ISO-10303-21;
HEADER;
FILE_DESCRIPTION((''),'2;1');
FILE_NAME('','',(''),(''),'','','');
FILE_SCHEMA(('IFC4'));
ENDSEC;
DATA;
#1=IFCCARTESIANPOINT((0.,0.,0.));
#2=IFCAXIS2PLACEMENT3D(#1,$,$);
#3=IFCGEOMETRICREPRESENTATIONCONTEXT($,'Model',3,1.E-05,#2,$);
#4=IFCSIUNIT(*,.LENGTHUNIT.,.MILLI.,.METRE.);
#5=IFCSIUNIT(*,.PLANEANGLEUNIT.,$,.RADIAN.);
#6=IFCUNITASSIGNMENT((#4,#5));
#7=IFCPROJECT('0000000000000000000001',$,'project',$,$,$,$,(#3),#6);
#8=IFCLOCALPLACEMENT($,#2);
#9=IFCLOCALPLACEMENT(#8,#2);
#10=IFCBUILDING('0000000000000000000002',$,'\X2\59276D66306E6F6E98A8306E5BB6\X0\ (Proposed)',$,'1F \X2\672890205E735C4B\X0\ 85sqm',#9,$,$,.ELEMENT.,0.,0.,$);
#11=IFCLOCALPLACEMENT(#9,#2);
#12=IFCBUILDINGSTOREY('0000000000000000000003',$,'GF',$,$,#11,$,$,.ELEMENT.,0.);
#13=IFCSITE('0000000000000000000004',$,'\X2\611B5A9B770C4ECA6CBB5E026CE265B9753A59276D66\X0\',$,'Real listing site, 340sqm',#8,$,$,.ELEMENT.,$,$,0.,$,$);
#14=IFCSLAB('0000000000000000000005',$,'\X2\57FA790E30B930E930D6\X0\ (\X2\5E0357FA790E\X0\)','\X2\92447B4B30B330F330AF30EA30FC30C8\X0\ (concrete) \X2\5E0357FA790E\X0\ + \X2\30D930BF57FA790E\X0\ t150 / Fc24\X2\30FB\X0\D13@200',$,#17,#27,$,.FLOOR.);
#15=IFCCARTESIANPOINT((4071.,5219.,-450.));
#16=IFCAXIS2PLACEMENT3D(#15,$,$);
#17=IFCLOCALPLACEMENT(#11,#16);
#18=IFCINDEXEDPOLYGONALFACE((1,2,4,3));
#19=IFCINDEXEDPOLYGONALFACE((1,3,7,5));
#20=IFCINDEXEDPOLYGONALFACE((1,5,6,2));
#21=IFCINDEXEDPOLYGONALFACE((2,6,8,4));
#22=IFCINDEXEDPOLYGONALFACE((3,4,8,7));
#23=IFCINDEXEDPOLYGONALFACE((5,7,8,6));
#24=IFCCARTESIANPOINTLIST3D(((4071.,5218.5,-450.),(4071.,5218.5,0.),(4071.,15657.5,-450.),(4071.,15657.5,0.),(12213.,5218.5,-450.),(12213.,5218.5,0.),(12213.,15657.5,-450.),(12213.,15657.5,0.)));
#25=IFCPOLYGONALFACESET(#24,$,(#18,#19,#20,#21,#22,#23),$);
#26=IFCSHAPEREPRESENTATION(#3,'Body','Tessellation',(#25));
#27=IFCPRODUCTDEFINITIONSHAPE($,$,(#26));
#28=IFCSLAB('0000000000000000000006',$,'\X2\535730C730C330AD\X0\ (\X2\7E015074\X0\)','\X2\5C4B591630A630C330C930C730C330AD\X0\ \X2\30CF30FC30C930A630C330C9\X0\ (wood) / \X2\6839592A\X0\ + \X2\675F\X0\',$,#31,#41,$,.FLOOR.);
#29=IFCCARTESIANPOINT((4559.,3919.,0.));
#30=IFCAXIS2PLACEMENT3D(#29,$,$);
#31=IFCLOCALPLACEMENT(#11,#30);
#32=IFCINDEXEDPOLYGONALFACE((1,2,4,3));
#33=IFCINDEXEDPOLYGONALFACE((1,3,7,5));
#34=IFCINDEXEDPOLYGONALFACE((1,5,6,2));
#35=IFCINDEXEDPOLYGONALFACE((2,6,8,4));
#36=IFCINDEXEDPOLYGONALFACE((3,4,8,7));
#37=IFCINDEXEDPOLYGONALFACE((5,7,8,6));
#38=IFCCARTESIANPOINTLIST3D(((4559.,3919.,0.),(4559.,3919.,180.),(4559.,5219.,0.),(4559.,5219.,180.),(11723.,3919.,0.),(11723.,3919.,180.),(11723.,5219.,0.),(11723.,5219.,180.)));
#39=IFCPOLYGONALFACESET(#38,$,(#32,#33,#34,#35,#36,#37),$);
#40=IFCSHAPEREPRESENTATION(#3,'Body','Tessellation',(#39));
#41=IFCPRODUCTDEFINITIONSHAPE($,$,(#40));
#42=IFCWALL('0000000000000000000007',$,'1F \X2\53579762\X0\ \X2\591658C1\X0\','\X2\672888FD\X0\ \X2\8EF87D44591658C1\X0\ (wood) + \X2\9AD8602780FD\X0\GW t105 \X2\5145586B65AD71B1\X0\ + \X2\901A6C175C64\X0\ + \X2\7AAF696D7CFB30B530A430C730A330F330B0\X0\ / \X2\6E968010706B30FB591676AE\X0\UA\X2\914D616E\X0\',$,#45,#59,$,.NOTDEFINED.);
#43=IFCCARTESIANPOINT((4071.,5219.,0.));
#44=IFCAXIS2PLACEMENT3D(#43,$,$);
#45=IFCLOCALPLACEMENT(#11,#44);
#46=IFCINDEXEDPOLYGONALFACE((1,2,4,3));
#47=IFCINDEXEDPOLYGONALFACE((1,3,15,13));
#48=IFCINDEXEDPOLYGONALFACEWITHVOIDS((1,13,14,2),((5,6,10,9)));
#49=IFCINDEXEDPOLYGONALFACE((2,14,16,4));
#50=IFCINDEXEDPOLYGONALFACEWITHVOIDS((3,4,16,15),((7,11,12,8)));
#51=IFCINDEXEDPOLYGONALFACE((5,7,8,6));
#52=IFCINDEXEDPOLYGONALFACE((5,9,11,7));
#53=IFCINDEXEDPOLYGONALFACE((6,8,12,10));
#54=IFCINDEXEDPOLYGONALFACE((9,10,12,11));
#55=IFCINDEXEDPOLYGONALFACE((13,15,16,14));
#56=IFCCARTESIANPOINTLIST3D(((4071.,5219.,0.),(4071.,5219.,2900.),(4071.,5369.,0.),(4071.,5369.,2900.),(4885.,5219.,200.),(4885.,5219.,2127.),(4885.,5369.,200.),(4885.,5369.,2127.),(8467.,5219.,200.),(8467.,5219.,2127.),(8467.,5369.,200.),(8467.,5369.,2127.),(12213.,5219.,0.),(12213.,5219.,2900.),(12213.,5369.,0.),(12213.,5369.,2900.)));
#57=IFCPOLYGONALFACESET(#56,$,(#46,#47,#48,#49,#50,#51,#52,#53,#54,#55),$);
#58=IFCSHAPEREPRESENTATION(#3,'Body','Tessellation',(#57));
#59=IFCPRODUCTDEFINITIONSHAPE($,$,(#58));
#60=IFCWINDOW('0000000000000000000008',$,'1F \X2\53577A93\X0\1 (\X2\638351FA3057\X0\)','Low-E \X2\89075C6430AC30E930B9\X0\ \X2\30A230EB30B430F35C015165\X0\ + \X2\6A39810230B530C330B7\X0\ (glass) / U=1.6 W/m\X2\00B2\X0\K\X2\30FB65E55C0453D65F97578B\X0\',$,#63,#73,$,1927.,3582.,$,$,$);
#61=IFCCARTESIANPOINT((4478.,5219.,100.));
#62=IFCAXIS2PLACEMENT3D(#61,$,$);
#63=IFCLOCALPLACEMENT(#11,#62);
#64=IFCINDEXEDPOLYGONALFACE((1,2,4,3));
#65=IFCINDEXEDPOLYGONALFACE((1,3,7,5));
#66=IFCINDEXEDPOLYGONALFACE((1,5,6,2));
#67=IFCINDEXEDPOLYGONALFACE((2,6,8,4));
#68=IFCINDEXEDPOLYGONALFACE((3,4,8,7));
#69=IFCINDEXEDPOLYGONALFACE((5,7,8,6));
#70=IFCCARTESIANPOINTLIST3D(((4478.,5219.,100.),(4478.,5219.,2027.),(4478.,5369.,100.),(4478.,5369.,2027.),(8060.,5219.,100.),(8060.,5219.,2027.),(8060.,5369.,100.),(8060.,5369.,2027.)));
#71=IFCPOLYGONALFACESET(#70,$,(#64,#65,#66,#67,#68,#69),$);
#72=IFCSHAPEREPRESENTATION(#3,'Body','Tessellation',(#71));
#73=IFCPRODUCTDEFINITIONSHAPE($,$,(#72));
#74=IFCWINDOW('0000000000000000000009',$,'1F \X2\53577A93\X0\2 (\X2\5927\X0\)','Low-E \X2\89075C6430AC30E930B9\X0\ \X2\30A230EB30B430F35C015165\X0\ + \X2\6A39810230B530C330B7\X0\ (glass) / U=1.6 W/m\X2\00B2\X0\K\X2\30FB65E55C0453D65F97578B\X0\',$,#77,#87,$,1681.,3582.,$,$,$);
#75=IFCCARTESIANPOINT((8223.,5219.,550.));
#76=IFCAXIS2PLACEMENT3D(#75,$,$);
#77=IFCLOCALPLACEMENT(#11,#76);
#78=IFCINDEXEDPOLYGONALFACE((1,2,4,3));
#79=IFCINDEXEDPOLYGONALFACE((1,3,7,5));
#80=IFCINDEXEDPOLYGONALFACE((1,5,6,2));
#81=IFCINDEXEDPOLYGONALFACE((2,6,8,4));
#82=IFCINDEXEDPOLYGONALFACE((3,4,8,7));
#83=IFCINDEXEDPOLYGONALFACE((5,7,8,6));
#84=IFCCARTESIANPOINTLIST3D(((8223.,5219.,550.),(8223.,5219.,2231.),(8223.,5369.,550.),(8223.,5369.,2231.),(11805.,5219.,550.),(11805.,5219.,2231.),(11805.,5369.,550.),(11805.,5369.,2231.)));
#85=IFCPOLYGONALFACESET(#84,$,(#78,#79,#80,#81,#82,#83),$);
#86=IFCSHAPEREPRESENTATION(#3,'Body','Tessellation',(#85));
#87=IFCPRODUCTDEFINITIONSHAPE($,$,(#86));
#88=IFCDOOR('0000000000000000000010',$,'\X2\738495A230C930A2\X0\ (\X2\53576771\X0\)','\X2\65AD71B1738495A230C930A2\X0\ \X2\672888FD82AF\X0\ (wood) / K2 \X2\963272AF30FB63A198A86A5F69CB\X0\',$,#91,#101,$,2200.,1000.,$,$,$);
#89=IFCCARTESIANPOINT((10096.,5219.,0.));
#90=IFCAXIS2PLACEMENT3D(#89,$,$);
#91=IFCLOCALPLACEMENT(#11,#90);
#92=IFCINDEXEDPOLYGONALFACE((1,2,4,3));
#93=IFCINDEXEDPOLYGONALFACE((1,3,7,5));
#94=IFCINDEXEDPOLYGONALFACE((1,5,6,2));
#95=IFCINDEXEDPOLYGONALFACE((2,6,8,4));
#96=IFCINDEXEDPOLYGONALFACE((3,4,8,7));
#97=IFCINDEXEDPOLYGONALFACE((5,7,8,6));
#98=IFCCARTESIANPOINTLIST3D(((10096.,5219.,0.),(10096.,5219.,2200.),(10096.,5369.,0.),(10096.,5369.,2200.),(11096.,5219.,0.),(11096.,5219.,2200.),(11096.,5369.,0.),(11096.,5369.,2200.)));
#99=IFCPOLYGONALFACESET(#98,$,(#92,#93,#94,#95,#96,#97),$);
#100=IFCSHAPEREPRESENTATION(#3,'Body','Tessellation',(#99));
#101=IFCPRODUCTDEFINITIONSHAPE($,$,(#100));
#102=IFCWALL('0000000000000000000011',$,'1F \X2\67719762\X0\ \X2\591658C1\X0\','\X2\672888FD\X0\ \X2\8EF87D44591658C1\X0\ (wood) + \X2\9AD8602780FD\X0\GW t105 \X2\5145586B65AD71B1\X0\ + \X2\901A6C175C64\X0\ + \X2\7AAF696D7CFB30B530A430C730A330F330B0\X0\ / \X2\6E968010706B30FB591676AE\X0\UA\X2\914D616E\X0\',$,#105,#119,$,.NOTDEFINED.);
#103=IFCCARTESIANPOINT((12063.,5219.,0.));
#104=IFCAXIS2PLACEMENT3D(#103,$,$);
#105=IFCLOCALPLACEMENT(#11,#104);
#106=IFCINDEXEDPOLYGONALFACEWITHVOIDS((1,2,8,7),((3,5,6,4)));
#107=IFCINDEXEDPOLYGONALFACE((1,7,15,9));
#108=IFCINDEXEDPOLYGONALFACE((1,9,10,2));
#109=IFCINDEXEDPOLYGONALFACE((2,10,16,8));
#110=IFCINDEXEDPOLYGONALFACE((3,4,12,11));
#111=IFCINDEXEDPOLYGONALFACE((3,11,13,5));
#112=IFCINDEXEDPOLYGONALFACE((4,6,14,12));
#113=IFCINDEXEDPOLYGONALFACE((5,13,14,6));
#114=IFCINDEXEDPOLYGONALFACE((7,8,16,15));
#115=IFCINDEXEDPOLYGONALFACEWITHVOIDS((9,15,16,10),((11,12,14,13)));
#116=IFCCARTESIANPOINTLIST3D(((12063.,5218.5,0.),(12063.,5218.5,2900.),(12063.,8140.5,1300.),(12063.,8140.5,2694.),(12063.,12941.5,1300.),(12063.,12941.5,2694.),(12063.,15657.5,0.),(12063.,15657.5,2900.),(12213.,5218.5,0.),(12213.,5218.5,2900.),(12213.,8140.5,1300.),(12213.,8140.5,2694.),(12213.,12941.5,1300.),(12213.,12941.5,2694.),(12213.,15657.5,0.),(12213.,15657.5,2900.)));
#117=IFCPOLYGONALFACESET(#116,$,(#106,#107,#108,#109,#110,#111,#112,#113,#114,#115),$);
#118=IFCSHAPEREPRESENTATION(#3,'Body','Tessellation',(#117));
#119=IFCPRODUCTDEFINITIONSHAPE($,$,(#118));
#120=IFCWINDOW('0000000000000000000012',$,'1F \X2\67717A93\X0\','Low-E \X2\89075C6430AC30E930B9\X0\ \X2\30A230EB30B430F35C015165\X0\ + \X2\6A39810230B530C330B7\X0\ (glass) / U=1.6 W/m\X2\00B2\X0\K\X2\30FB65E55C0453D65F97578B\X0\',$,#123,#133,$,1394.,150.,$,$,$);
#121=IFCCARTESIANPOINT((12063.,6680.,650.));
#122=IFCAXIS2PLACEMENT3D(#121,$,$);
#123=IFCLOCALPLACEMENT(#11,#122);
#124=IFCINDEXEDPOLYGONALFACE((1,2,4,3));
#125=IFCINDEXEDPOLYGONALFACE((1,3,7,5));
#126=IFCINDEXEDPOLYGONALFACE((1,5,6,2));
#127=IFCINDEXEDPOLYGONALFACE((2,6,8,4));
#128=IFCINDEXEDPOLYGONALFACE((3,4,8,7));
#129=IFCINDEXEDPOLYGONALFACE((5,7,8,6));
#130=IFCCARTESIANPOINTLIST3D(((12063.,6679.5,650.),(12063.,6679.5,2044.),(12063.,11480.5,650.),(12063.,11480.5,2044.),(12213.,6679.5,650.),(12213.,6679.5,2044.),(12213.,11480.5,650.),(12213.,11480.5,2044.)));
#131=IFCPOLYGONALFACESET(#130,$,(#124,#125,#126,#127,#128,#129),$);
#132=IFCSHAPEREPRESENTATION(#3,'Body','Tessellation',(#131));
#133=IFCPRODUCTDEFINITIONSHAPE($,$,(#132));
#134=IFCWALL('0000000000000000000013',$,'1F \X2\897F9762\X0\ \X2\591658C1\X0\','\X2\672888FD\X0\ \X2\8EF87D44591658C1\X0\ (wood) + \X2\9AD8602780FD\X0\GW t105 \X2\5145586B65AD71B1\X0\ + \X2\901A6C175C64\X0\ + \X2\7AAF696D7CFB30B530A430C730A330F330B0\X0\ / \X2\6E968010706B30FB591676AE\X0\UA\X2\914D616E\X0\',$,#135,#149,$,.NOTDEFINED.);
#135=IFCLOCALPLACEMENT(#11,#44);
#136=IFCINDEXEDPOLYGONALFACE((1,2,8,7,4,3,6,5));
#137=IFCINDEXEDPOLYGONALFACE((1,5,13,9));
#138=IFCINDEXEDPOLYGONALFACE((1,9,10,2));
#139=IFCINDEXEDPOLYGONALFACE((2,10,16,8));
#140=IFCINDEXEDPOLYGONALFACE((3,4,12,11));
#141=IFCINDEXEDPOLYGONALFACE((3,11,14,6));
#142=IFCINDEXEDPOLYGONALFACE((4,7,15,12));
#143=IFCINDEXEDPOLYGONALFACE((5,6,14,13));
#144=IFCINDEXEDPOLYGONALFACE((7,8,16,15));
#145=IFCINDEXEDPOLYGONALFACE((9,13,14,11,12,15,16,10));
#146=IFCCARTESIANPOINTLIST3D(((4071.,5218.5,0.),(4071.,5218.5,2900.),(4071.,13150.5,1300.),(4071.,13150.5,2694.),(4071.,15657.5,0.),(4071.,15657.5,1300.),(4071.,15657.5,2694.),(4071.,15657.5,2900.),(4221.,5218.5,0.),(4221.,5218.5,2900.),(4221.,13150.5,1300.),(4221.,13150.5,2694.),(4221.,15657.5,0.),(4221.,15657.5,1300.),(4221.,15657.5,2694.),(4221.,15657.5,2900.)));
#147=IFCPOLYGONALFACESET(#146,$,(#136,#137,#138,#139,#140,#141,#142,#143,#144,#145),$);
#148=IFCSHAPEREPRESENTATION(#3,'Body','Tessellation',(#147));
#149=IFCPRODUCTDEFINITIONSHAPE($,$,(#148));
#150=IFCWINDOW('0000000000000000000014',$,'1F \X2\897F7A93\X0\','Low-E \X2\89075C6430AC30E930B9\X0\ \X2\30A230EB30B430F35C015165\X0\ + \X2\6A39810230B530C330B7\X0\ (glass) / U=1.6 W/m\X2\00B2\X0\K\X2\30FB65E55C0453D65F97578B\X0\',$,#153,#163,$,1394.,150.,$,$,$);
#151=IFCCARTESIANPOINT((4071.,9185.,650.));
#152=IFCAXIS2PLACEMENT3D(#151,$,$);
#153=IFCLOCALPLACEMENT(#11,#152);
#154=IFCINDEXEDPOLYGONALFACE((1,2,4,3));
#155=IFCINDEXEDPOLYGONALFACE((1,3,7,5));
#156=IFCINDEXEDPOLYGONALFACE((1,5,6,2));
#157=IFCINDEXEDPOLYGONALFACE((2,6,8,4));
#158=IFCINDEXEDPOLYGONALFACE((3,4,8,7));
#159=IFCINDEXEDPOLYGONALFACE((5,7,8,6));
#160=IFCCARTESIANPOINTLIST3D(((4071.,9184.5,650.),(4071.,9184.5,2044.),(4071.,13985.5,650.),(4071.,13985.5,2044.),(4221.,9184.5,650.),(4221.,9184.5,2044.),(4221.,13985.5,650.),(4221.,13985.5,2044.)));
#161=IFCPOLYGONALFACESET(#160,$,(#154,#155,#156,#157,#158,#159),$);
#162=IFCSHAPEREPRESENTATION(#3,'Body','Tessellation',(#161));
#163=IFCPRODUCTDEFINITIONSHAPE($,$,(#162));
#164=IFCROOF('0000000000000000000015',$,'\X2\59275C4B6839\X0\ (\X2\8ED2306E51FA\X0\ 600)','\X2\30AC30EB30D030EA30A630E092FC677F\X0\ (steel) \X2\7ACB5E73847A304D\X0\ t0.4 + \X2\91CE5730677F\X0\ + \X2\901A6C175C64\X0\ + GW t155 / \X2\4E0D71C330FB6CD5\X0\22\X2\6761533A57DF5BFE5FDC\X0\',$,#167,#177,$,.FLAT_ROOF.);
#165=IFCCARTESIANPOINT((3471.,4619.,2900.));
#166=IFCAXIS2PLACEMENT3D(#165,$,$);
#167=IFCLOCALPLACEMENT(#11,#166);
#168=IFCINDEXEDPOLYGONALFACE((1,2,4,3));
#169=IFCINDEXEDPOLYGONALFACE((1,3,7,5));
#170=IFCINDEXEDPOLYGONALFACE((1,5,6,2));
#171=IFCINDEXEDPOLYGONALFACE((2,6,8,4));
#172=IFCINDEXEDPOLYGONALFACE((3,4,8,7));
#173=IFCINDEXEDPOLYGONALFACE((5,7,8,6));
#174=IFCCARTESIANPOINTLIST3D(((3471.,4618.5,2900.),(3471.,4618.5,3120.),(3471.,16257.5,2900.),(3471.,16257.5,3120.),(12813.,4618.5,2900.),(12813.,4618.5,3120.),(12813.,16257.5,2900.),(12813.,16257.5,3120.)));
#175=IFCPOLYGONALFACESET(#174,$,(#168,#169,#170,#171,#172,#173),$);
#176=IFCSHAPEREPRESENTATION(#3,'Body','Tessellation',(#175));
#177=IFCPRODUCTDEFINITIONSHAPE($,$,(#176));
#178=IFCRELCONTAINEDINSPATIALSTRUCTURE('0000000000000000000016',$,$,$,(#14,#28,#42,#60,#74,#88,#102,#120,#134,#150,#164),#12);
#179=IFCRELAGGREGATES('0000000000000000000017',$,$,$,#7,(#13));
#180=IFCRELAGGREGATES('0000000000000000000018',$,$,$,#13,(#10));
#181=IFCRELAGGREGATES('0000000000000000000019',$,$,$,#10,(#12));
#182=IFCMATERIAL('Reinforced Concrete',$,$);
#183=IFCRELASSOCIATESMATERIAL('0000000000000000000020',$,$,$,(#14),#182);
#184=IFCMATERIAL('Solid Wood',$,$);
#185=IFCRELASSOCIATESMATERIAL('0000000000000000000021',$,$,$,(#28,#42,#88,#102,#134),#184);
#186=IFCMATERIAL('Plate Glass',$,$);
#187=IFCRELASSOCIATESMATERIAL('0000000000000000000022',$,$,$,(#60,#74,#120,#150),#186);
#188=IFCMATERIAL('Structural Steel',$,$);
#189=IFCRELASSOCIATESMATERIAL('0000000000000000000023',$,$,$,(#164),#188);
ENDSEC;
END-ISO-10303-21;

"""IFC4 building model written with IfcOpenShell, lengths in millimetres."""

from ifc_helpers import new_model, si_unit, frame, frame_2d, origin, place, context, project, spatial, rectangle, extrude, material, element, fill, save


model = new_model("IFC4")

# Units and contexts
model_context = context("Model", 3, precision=1e-05, world=origin())
ifc_project = project(units=[si_unit("LENGTHUNIT", "METRE", prefix="MILLI"), si_unit("PLANEANGLEUNIT", "RADIAN")], contexts=[model_context])

# Site, building, storey
site_placement = place(None, origin())
site = spatial("IfcSite", under=ifc_project, at=site_placement, Name="愛媛県今治市波方町大浦", ObjectType="Real listing site, 340sqm", CompositionType="ELEMENT", RefElevation=0.0)
building_placement = place(site_placement, origin())
building = spatial("IfcBuilding", under=site, at=building_placement, Name="大浦の潮風の家 (Proposed)", ObjectType="1F 木造平屋 85sqm", CompositionType="ELEMENT", ElevationOfRefHeight=0.0, ElevationOfTerrain=0.0)
storey_placement = place(building_placement, origin())
storey = spatial("IfcBuildingStorey", under=building, at=storey_placement, Name="GF", CompositionType="ELEMENT", Elevation=0.0)

# Slabs
ifc_material_1 = material(Name="Reinforced Concrete")
slab_1_placement = place(storey_placement, frame((4071.0, 5219.0, -450.0)))
element("IfcSlab", 1, at=slab_1_placement, inside=storey, material=ifc_material_1, Name="基礎スラブ (布基礎)", Description="鉄筋コンクリート (concrete) 布基礎 + ベタ基礎 t150 / Fc24・D13@200", PredefinedType="FLOOR", context=model_context, shape_type="SweptSolid", body=[
    extrude(rectangle(XDim=8142.0, YDim=10439.0, at=frame_2d((4071.0, 5219.0))), frame((4071.0, 5219.0, -450.0)), (0.0, 0.0, 1.0), 450.0),
])
ifc_material_2 = material(Name="Solid Wood")
slab_2_placement = place(storey_placement, frame((4559.0, 3919.0, 0.0)))
element("IfcSlab", 2, at=slab_2_placement, inside=storey, material=ifc_material_2, Name="南デッキ (縁側)", Description="屋外ウッドデッキ ハードウッド (wood) / 根太 + 束", PredefinedType="FLOOR", context=model_context, shape_type="SweptSolid", body=[
    extrude(rectangle(XDim=7164.0, YDim=1300.0, at=frame_2d((3582.0, 650.0))), frame((4559.0, 3919.0, 0.0)), (0.0, 0.0, 1.0), 180.0),
])

# Wall, openings, windows, door
wall_1_placement = place(storey_placement, frame((4071.0, 5219.0, 0.0)))
wall_1 = element("IfcWall", 3, at=wall_1_placement, inside=storey, material=ifc_material_2, Name="1F 南面 外壁", Description="木製 軸組外壁 (wood) + 高性能GW t105 充填断熱 + 通気層 + 窯業系サイディング / 準耐火・外皮UA配慮", PredefinedType="NOTDEFINED", context=model_context, shape_type="SweptSolid", body=[
    extrude(rectangle(XDim=8142.0, YDim=150.0, at=frame_2d((4071.0, 75.0))), frame((4071.0, 5219.0, 0.0)), (0.0, 0.0, 1.0), 2900.0),
])
opening_1_placement = place(storey_placement, frame((4478.0, 5219.0, 100.0)))
opening_1 = element("IfcOpeningElement", 4, at=opening_1_placement, cuts=wall_1, PredefinedType="NOTDEFINED", context=model_context, shape_type="SweptSolid", body=[
    extrude(rectangle(XDim=3582.0, YDim=150.0, at=frame_2d((1791.0, 75.0))), frame((4478.0, 5219.0, 100.0)), (0.0, 0.0, 1.0), 1927.0),
])
opening_2_placement = place(storey_placement, frame((8223.0, 5219.0, 550.0)))
opening_2 = element("IfcOpeningElement", 5, at=opening_2_placement, cuts=wall_1, PredefinedType="NOTDEFINED", context=model_context, shape_type="SweptSolid", body=[
    extrude(rectangle(XDim=3582.0, YDim=150.0, at=frame_2d((1791.0, 75.0))), frame((8223.0, 5219.0, 550.0)), (0.0, 0.0, 1.0), 1681.0),
])
opening_3_placement = place(storey_placement, frame((10096.0, 5219.0, 0.0)))
opening_3 = element("IfcOpeningElement", 6, at=opening_3_placement, cuts=wall_1, PredefinedType="NOTDEFINED", context=model_context, shape_type="SweptSolid", body=[
    extrude(rectangle(XDim=1000.0, YDim=150.0, at=frame_2d((500.0, 75.0))), frame((10096.0, 5219.0, 0.0)), (0.0, 0.0, 1.0), 2200.0),
])
ifc_material_3 = material(Name="Plate Glass")
window_1_placement = place(storey_placement, frame((4478.0, 5219.0, 100.0)))
window_1 = element("IfcWindow", 7, at=window_1_placement, inside=storey, material=ifc_material_3, Name="1F 南窓1 (掃出し)", Description="Low-E 複層ガラス アルゴン封入 + 樹脂サッシ (glass) / U=1.6 W/m²K・日射取得型", OverallHeight=1927.0, OverallWidth=3582.0, context=model_context, shape_type="SweptSolid", body=[
    extrude(rectangle(XDim=3582.0, YDim=150.0, at=frame_2d((1791.0, 75.0))), frame((4478.0, 5219.0, 100.0)), (0.0, 0.0, 1.0), 1927.0),
])
fill(opening_1, window_1)
window_2_placement = place(storey_placement, frame((8223.0, 5219.0, 550.0)))
window_2 = element("IfcWindow", 8, at=window_2_placement, inside=storey, material=ifc_material_3, Name="1F 南窓2 (大)", Description="Low-E 複層ガラス アルゴン封入 + 樹脂サッシ (glass) / U=1.6 W/m²K・日射取得型", OverallHeight=1681.0, OverallWidth=3582.0, context=model_context, shape_type="SweptSolid", body=[
    extrude(rectangle(XDim=3582.0, YDim=150.0, at=frame_2d((1791.0, 75.0))), frame((8223.0, 5219.0, 550.0)), (0.0, 0.0, 1.0), 1681.0),
])
fill(opening_2, window_2)
door_placement = place(storey_placement, frame((10096.0, 5219.0, 0.0)))
door = element("IfcDoor", 9, at=door_placement, inside=storey, material=ifc_material_2, Name="玄関ドア (南東)", Description="断熱玄関ドア 木製芯 (wood) / K2 防犯・採風機構", OverallHeight=2200.0, OverallWidth=1000.0, context=model_context, shape_type="SweptSolid", body=[
    extrude(rectangle(XDim=1000.0, YDim=150.0, at=frame_2d((500.0, 75.0))), frame((10096.0, 5219.0, 0.0)), (0.0, 0.0, 1.0), 2200.0),
])
fill(opening_3, door)

# Walls, openings, windows
wall_2_placement = place(storey_placement, frame((12063.0, 5219.0, 0.0)))
wall_2 = element("IfcWall", 10, at=wall_2_placement, inside=storey, material=ifc_material_2, Name="1F 東面 外壁", Description="木製 軸組外壁 (wood) + 高性能GW t105 充填断熱 + 通気層 + 窯業系サイディング / 準耐火・外皮UA配慮", PredefinedType="NOTDEFINED", context=model_context, shape_type="SweptSolid", body=[
    extrude(rectangle(XDim=150.0, YDim=10439.0, at=frame_2d((75.0, 5219.0))), frame((12063.0, 5219.0, 0.0)), (0.0, 0.0, 1.0), 2900.0),
])
opening_4_placement = place(storey_placement, frame((12063.0, 6680.0, 650.0)))
opening_4 = element("IfcOpeningElement", 11, at=opening_4_placement, cuts=wall_2, PredefinedType="NOTDEFINED", context=model_context, shape_type="SweptSolid", body=[
    extrude(rectangle(XDim=150.0, YDim=4801.0, at=frame_2d((75.0, 2400.0))), frame((12063.0, 6680.0, 650.0)), (0.0, 0.0, 1.0), 1394.0),
])
window_3_placement = place(storey_placement, frame((12063.0, 6680.0, 650.0)))
window_3 = element("IfcWindow", 12, at=window_3_placement, inside=storey, material=ifc_material_3, Name="1F 東窓", Description="Low-E 複層ガラス アルゴン封入 + 樹脂サッシ (glass) / U=1.6 W/m²K・日射取得型", OverallHeight=1394.0, OverallWidth=150.0, context=model_context, shape_type="SweptSolid", body=[
    extrude(rectangle(XDim=150.0, YDim=4801.0, at=frame_2d((75.0, 2400.0))), frame((12063.0, 6680.0, 650.0)), (0.0, 0.0, 1.0), 1394.0),
])
fill(opening_4, window_3)
wall_3_placement = place(storey_placement, frame((4071.0, 5219.0, 0.0)))
wall_3 = element("IfcWall", 13, at=wall_3_placement, inside=storey, material=ifc_material_2, Name="1F 西面 外壁", Description="木製 軸組外壁 (wood) + 高性能GW t105 充填断熱 + 通気層 + 窯業系サイディング / 準耐火・外皮UA配慮", PredefinedType="NOTDEFINED", context=model_context, shape_type="SweptSolid", body=[
    extrude(rectangle(XDim=150.0, YDim=10439.0, at=frame_2d((75.0, 5219.0))), frame((4071.0, 5219.0, 0.0)), (0.0, 0.0, 1.0), 2900.0),
])
opening_5_placement = place(storey_placement, frame((4071.0, 9185.0, 650.0)))
opening_5 = element("IfcOpeningElement", 14, at=opening_5_placement, cuts=wall_3, PredefinedType="NOTDEFINED", context=model_context, shape_type="SweptSolid", body=[
    extrude(rectangle(XDim=150.0, YDim=4801.0, at=frame_2d((75.0, 2400.0))), frame((4071.0, 9185.0, 650.0)), (0.0, 0.0, 1.0), 1394.0),
])
window_4_placement = place(storey_placement, frame((4071.0, 9185.0, 650.0)))
window_4 = element("IfcWindow", 15, at=window_4_placement, inside=storey, material=ifc_material_3, Name="1F 西窓", Description="Low-E 複層ガラス アルゴン封入 + 樹脂サッシ (glass) / U=1.6 W/m²K・日射取得型", OverallHeight=1394.0, OverallWidth=150.0, context=model_context, shape_type="SweptSolid", body=[
    extrude(rectangle(XDim=150.0, YDim=4801.0, at=frame_2d((75.0, 2400.0))), frame((4071.0, 9185.0, 650.0)), (0.0, 0.0, 1.0), 1394.0),
])
fill(opening_5, window_4)

# Roof
ifc_material_4 = material(Name="Structural Steel")
roof_placement = place(storey_placement, frame((3471.0, 4619.0, 2900.0)))
element("IfcRoof", 16, at=roof_placement, inside=storey, material=ifc_material_4, Name="大屋根 (軒の出 600)", Description="ガルバリウム鋼板 (steel) 立平葺き t0.4 + 野地板 + 通気層 + GW t155 / 不燃・法22条区域対応", PredefinedType="FLAT_ROOF", context=model_context, shape_type="SweptSolid", body=[
    extrude(rectangle(XDim=9342.0, YDim=11639.0, at=frame_2d((4671.0, 5819.0))), frame((3471.0, 4619.0, 2900.0)), (0.0, 0.0, 1.0), 220.0),
])

save(model, "model.ifc")
